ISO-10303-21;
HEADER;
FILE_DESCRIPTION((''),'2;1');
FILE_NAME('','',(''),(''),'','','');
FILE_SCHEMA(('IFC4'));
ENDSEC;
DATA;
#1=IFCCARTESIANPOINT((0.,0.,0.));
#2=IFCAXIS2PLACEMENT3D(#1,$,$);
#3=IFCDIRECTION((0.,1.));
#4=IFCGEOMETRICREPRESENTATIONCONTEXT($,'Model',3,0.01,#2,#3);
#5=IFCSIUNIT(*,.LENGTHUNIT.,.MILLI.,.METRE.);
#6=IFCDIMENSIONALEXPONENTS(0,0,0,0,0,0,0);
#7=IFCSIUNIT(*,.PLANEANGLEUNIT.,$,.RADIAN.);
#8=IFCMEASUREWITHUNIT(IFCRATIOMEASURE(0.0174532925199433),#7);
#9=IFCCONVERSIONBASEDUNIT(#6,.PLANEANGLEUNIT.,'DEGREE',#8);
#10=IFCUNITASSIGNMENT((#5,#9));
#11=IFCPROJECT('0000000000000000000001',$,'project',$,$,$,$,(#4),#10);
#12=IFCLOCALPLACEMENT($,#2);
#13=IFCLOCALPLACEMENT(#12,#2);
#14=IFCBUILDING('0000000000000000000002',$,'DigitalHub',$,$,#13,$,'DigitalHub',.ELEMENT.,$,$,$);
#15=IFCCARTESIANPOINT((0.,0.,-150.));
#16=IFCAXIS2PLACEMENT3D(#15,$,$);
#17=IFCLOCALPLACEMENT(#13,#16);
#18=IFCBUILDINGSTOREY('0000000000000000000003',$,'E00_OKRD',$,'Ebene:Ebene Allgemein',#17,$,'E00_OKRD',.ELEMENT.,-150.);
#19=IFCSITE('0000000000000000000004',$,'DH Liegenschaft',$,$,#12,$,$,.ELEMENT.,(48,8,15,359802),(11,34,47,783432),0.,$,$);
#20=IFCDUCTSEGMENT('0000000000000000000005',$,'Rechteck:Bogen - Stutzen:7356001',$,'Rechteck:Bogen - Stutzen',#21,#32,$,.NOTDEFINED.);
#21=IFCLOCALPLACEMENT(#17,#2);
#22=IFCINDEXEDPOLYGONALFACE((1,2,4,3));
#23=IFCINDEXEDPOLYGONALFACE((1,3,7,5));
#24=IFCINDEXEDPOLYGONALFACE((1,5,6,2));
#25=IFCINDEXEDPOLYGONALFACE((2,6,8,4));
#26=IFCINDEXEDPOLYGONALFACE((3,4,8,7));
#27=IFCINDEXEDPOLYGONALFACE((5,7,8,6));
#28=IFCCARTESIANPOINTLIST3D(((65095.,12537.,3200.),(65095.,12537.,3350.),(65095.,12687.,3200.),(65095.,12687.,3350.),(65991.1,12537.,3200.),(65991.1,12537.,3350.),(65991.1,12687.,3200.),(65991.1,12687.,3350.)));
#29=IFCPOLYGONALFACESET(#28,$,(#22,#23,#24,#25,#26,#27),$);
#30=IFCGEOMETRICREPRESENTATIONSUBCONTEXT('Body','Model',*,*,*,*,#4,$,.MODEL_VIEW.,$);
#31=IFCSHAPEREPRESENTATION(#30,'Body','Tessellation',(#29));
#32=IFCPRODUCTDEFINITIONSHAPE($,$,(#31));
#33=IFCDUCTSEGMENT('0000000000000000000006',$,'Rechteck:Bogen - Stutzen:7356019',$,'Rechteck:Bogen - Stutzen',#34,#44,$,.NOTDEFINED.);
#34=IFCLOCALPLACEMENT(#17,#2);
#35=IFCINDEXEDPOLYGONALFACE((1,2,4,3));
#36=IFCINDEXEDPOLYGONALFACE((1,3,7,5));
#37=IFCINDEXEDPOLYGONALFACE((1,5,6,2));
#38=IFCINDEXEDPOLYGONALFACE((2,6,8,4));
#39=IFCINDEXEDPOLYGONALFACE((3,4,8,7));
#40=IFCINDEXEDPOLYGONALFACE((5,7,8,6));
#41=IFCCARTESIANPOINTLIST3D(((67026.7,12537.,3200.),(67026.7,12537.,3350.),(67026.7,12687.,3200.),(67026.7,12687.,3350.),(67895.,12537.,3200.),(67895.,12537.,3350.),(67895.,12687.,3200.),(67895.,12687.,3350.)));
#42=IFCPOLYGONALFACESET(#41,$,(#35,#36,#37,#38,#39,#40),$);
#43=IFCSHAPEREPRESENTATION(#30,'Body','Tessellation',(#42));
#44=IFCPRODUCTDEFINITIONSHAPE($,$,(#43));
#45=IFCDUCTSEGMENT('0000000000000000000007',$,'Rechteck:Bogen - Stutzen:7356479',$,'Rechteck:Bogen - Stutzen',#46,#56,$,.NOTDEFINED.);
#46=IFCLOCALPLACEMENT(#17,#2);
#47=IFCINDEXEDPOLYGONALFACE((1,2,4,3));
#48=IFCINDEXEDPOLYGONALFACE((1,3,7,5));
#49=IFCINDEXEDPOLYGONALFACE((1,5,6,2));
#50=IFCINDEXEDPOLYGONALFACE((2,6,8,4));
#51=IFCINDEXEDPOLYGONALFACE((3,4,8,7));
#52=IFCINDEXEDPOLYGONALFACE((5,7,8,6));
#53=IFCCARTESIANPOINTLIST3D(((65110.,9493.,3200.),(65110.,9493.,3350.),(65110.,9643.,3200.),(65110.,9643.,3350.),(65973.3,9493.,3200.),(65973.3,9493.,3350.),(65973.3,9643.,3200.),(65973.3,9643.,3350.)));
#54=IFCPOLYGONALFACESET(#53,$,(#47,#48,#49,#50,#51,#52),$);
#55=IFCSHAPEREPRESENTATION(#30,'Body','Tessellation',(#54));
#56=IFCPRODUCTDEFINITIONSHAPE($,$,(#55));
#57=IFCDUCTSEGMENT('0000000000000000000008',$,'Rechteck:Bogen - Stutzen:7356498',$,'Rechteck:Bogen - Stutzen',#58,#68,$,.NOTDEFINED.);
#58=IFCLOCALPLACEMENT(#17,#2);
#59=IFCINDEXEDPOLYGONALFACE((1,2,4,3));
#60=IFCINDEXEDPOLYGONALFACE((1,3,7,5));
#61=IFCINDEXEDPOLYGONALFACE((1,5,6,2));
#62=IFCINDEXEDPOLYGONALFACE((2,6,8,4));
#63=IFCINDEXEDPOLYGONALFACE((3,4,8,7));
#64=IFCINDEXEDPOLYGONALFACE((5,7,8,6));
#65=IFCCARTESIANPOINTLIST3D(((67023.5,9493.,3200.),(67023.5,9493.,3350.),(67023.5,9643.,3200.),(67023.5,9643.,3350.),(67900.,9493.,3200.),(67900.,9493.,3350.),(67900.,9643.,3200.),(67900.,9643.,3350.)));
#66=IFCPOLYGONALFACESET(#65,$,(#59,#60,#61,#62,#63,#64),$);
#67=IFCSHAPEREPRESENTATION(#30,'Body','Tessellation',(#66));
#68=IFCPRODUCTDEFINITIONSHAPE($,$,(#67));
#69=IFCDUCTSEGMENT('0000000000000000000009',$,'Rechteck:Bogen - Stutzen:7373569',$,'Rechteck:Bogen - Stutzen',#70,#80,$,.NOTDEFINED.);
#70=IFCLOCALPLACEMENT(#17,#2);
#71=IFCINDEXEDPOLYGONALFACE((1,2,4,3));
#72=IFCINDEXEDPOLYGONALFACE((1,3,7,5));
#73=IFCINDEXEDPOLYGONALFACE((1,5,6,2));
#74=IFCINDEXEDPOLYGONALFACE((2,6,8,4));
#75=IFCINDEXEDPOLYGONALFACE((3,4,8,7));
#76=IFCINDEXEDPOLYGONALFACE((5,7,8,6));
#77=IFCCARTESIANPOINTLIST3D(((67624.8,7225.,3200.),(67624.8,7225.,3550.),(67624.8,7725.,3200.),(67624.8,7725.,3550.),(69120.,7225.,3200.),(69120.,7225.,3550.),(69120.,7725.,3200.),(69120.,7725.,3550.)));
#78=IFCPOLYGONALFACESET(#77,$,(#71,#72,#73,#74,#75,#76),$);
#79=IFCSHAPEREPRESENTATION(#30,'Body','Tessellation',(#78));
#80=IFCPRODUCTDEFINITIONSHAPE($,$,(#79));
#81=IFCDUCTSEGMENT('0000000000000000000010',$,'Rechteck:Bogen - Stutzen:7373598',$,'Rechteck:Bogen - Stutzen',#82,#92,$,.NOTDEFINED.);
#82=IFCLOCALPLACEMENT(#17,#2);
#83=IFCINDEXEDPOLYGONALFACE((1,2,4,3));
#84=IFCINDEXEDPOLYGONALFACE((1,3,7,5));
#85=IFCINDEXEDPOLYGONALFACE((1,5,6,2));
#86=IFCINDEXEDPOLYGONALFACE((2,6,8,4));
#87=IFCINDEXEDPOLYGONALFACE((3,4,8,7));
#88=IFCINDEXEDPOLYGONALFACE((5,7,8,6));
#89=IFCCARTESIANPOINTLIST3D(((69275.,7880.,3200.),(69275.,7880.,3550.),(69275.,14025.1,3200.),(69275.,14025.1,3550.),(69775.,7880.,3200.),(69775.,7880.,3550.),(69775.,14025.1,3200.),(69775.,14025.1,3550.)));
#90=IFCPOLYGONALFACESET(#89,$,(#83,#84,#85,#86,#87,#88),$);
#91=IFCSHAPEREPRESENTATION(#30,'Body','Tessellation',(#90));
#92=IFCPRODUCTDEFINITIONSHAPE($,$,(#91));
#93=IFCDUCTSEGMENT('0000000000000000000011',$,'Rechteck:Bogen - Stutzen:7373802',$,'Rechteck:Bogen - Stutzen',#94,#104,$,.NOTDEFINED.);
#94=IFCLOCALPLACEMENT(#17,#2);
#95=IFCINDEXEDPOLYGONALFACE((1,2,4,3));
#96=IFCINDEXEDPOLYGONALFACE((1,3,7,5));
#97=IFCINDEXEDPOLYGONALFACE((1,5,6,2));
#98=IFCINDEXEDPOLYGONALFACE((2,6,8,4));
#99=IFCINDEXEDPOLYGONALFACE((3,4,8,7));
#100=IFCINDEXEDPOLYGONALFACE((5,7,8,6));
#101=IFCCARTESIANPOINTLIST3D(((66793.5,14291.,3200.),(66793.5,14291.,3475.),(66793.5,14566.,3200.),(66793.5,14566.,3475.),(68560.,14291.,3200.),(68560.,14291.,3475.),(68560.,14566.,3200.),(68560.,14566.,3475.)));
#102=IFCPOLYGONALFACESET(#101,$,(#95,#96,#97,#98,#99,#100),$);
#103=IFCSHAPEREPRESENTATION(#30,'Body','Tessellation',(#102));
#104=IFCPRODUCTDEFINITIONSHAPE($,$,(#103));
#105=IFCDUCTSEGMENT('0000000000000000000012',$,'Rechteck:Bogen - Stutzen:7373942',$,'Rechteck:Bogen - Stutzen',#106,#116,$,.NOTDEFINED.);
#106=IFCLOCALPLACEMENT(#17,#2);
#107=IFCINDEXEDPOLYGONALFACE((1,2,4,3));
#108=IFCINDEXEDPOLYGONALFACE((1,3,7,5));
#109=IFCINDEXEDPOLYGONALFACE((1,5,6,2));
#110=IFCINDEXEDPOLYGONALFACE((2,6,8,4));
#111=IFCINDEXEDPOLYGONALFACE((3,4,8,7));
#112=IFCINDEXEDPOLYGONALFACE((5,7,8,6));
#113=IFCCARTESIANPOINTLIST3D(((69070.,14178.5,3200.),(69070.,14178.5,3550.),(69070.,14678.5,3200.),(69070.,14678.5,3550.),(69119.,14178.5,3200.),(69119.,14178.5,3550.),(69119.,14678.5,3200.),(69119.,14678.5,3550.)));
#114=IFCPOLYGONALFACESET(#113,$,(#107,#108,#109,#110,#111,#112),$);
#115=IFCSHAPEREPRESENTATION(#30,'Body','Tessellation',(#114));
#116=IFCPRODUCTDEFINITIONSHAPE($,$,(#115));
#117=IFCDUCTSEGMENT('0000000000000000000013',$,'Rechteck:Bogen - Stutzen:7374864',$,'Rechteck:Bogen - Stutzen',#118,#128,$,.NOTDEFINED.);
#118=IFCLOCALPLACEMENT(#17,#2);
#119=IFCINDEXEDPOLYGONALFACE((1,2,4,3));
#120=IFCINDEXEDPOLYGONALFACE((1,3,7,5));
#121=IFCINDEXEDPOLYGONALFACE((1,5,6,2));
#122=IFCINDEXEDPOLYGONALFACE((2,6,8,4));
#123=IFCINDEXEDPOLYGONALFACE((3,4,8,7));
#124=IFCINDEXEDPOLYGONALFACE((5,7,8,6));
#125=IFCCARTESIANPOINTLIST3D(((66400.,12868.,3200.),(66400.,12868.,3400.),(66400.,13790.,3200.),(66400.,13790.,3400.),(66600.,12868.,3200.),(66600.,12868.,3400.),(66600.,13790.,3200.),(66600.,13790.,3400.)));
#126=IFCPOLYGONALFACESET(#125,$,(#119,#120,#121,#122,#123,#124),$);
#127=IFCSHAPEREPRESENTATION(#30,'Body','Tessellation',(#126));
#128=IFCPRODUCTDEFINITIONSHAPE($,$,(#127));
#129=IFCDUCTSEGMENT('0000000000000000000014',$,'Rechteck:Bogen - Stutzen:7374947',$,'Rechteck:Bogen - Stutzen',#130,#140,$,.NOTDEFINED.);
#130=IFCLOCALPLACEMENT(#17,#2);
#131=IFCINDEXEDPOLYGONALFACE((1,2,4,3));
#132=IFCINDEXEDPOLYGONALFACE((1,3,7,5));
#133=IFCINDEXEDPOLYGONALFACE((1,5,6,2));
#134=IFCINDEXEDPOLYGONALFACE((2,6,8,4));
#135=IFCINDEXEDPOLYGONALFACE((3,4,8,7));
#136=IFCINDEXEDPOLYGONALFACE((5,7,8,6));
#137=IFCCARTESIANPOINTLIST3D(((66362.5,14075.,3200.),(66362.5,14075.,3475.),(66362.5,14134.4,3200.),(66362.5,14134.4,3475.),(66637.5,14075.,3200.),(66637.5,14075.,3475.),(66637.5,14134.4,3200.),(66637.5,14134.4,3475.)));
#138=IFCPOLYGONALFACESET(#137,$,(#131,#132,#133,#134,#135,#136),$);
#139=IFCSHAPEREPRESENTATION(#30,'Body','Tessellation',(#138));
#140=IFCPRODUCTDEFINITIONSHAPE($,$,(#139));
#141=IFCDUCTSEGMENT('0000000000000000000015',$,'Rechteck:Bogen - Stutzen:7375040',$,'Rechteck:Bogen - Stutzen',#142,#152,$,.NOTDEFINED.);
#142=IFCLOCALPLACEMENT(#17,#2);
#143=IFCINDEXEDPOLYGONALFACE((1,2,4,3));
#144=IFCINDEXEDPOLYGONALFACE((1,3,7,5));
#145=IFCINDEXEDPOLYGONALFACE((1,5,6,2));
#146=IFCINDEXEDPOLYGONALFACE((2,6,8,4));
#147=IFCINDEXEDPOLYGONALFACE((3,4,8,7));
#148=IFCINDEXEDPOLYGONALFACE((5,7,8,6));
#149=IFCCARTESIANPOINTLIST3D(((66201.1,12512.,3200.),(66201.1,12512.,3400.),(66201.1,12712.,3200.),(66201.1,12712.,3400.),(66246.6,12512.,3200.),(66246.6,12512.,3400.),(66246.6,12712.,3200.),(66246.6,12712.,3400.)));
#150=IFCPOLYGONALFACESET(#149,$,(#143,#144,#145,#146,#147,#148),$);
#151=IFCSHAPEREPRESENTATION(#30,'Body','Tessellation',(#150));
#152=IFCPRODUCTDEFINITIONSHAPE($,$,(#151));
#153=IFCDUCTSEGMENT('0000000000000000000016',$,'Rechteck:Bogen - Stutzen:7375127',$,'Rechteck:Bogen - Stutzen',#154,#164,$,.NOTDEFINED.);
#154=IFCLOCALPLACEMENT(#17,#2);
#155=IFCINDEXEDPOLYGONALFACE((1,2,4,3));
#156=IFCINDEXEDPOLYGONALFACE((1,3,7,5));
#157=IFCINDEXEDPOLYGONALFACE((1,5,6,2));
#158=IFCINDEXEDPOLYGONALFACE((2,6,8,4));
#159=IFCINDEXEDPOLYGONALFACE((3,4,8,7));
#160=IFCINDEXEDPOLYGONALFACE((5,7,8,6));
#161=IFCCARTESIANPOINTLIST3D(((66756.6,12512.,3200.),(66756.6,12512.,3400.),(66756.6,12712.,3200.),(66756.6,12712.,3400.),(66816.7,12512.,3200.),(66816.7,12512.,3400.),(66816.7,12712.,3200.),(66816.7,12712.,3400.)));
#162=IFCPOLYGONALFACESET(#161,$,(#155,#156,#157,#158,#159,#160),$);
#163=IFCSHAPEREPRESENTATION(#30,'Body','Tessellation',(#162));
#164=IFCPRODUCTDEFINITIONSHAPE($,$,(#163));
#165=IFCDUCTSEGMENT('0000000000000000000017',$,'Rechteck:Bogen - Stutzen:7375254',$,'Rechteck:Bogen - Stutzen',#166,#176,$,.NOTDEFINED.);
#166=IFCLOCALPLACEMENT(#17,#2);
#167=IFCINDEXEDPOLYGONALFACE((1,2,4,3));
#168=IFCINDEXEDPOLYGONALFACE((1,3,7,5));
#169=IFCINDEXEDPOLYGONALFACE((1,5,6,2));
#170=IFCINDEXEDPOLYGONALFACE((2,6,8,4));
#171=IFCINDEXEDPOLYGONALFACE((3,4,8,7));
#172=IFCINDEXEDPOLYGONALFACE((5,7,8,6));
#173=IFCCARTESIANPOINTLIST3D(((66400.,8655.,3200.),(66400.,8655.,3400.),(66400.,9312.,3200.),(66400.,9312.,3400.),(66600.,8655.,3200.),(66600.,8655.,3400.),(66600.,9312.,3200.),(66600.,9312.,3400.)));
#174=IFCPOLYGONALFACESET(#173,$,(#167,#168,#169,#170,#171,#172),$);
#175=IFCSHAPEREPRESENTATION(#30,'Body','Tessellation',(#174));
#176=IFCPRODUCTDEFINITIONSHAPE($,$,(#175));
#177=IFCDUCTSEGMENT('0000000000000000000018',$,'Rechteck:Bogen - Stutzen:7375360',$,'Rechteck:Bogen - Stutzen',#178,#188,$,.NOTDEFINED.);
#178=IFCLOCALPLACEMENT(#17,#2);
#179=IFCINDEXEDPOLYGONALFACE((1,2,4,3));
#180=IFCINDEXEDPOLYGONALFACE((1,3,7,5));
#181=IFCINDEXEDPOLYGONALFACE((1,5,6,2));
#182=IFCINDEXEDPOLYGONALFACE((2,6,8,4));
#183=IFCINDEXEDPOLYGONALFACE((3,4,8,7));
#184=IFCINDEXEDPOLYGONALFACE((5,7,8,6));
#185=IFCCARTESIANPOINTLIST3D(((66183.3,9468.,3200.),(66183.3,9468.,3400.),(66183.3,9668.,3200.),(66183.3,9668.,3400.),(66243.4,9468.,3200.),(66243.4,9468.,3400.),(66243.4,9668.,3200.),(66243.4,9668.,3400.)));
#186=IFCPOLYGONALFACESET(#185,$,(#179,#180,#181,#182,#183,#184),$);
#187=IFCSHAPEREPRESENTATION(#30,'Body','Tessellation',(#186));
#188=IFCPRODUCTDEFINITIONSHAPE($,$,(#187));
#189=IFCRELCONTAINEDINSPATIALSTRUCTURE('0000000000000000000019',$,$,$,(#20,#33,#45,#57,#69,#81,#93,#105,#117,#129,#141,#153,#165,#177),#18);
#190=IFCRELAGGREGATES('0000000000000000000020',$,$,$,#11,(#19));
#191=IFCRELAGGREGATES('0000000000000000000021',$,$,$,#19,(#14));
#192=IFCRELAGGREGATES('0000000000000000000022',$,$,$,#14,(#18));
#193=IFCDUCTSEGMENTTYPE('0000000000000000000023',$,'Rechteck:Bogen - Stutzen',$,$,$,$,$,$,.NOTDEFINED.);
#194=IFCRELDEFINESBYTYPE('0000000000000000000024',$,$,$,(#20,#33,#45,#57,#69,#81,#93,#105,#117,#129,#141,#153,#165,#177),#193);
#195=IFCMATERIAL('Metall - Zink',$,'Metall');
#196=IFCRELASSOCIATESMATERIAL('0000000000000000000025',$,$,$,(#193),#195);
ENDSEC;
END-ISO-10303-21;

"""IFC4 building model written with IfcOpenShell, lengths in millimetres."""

from ifc_helpers import new_model, entity, si_unit, converted_unit, direction, frame, origin, place, context, subcontext, project, spatial, indexed_curve, outline, extrude, material, type_object, element, save


model = new_model("IFC4")

# Units and contexts
model_context = context("Model", 3, precision=0.01, world=origin(), true_north=direction((0.0, 1.0)))
body_context = subcontext(model_context, "Body", "Model", "MODEL_VIEW")
ifc_project = project(units=[si_unit("LENGTHUNIT", "METRE", prefix="MILLI"), converted_unit("PLANEANGLEUNIT", "DEGREE", entity("IfcRatioMeasure", 0.0174532925199433), si_unit("PLANEANGLEUNIT", "RADIAN"), dimensions=[0, 0, 0, 0, 0, 0, 0])], contexts=[model_context])

# Site, building, storey
site_placement = place(None, origin())
site = spatial("IfcSite", under=ifc_project, at=site_placement, Name="DH Liegenschaft", CompositionType="ELEMENT", RefLatitude=(48, 8, 15, 359802), RefLongitude=(11, 34, 47, 783432), RefElevation=0.0)
building_placement = place(site_placement, origin())
building = spatial("IfcBuilding", under=site, at=building_placement, Name="DigitalHub", LongName="DigitalHub", CompositionType="ELEMENT")
storey_placement = place(building_placement, frame((0.0, 0.0, -150.0)))
storey = spatial("IfcBuildingStorey", under=building, at=storey_placement, Name="E00_OKRD", ObjectType="Ebene:Ebene Allgemein", LongName="E00_OKRD", CompositionType="ELEMENT", Elevation=-150.0)

# Duct segments
ifc_material_1 = material(Name="Metall - Zink", Category="Metall")
duct_segment_type_1 = type_object("IfcDuctSegmentType", Name="Rechteck:Bogen - Stutzen", PredefinedType="NOTDEFINED", material=ifc_material_1)
duct_segment_1_placement = place(storey_placement, frame((65095.0, 12537.0, 3200.0)))
element("IfcDuctSegment", 1, at=duct_segment_1_placement, inside=storey, type_object=duct_segment_type_1, Name="Rechteck:Bogen - Stutzen:7356001", ObjectType="Rechteck:Bogen - Stutzen", PredefinedType="NOTDEFINED", context=body_context, shape_type="SweptSolid", body=[
    extrude(outline(indexed_curve([(-448.1, -75.0), (448.1, -75.0), (448.1, 75.0), (-448.1, 75.0), (-448.1, -75.0)], self_intersect=False)), frame((448.1, 75.0, 0.0)), (0.0, 0.0, 1.0), 150.0),
])
duct_segment_2_placement = place(storey_placement, frame((67026.7, 12537.0, 3200.0)))
element("IfcDuctSegment", 2, at=duct_segment_2_placement, inside=storey, type_object=duct_segment_type_1, Name="Rechteck:Bogen - Stutzen:7356019", ObjectType="Rechteck:Bogen - Stutzen", PredefinedType="NOTDEFINED", context=body_context, shape_type="SweptSolid", body=[
    extrude(outline(indexed_curve([(-434.2, -75.0), (434.2, -75.0), (434.2, 75.0), (-434.2, 75.0), (-434.2, -75.0)], self_intersect=False)), frame((434.2, 75.0, 0.0), z_axis=(0.0, 0.0, 1.0), x_axis=(-1.0, 0.0, 0.0)), (0.0, 0.0, 1.0), 150.0),
])
duct_segment_3_placement = place(storey_placement, frame((65110.0, 9493.0, 3200.0)))
element("IfcDuctSegment", 3, at=duct_segment_3_placement, inside=storey, type_object=duct_segment_type_1, Name="Rechteck:Bogen - Stutzen:7356479", ObjectType="Rechteck:Bogen - Stutzen", PredefinedType="NOTDEFINED", context=body_context, shape_type="SweptSolid", body=[
    extrude(outline(indexed_curve([(-431.7, -75.0), (431.7, -75.0), (431.7, 75.0), (-431.7, 75.0), (-431.7, -75.0)], self_intersect=False)), frame((431.7, 75.0, 0.0)), (0.0, 0.0, 1.0), 150.0),
])
duct_segment_4_placement = place(storey_placement, frame((67023.5, 9493.0, 3200.0)))
element("IfcDuctSegment", 4, at=duct_segment_4_placement, inside=storey, type_object=duct_segment_type_1, Name="Rechteck:Bogen - Stutzen:7356498", ObjectType="Rechteck:Bogen - Stutzen", PredefinedType="NOTDEFINED", context=body_context, shape_type="SweptSolid", body=[
    extrude(outline(indexed_curve([(-438.3, -75.0), (438.3, -75.0), (438.3, 75.0), (-438.3, 75.0), (-438.3, -75.0)], self_intersect=False)), frame((438.3, 75.0, 0.0), z_axis=(0.0, 0.0, 1.0), x_axis=(-1.0, 0.0, 0.0)), (0.0, 0.0, 1.0), 150.0),
])
duct_segment_5_placement = place(storey_placement, frame((67624.8, 7225.0, 3200.0)))
element("IfcDuctSegment", 5, at=duct_segment_5_placement, inside=storey, type_object=duct_segment_type_1, Name="Rechteck:Bogen - Stutzen:7373569", ObjectType="Rechteck:Bogen - Stutzen", PredefinedType="NOTDEFINED", context=body_context, shape_type="SweptSolid", body=[
    extrude(outline(indexed_curve([(-747.6, -250.0), (747.6, -250.0), (747.6, 250.0), (-747.6, 250.0), (-747.6, -250.0)], self_intersect=False)), frame((747.6, 250.0, 0.0), z_axis=(0.0, 0.0, 1.0), x_axis=(-1.0, 0.0, 0.0)), (0.0, 0.0, 1.0), 350.0),
])
duct_segment_6_placement = place(storey_placement, frame((69275.0, 7880.0, 3200.0)))
element("IfcDuctSegment", 6, at=duct_segment_6_placement, inside=storey, type_object=duct_segment_type_1, Name="Rechteck:Bogen - Stutzen:7373598", ObjectType="Rechteck:Bogen - Stutzen", PredefinedType="NOTDEFINED", context=body_context, shape_type="SweptSolid", body=[
    extrude(outline(indexed_curve([(-3072.6, -250.0), (3072.6, -250.0), (3072.6, 250.0), (-3072.6, 250.0), (-3072.6, -250.0)], self_intersect=False)), frame((250.0, 3072.6, 0.0), z_axis=(0.0, 0.0, 1.0), x_axis=(0.0, 1.0, 0.0)), (0.0, 0.0, 1.0), 350.0),
])
duct_segment_7_placement = place(storey_placement, frame((66793.5, 14291.0, 3200.0)))
element("IfcDuctSegment", 7, at=duct_segment_7_placement, inside=storey, type_object=duct_segment_type_1, Name="Rechteck:Bogen - Stutzen:7373802", ObjectType="Rechteck:Bogen - Stutzen", PredefinedType="NOTDEFINED", context=body_context, shape_type="SweptSolid", body=[
    extrude(outline(indexed_curve([(-883.3, -137.5), (883.2, -137.5), (883.2, 137.5), (-883.3, 137.5), (-883.3, -137.5)], self_intersect=False)), frame((883.2, 137.5, 0.0)), (0.0, 0.0, 1.0), 275.0),
])
duct_segment_8_placement = place(storey_placement, frame((69070.0, 14178.5, 3200.0)))
element("IfcDuctSegment", 8, at=duct_segment_8_placement, inside=storey, type_object=duct_segment_type_1, Name="Rechteck:Bogen - Stutzen:7373942", ObjectType="Rechteck:Bogen - Stutzen", PredefinedType="NOTDEFINED", context=body_context, shape_type="SweptSolid", body=[
    extrude(outline(indexed_curve([(-24.5, -250.0), (24.5, -250.0), (24.5, 250.0), (-24.5, 250.0), (-24.5, -250.0)], self_intersect=False)), frame((24.5, 250.0, 0.0)), (0.0, 0.0, 1.0), 350.0),
])
duct_segment_9_placement = place(storey_placement, frame((66400.0, 12868.0, 3200.0)))
element("IfcDuctSegment", 9, at=duct_segment_9_placement, inside=storey, type_object=duct_segment_type_1, Name="Rechteck:Bogen - Stutzen:7374864", ObjectType="Rechteck:Bogen - Stutzen", PredefinedType="NOTDEFINED", context=body_context, shape_type="SweptSolid", body=[
    extrude(outline(indexed_curve([(-461.0, -100.0), (461.0, -100.0), (461.0, 100.0), (-461.0, 100.0), (-461.0, -100.0)], self_intersect=False)), frame((100.0, 461.0, 0.0), z_axis=(0.0, 0.0, 1.0), x_axis=(0.0, 1.0, 0.0)), (0.0, 0.0, 1.0), 200.0),
])
duct_segment_10_placement = place(storey_placement, frame((66362.5, 14075.0, 3200.0)))
element("IfcDuctSegment", 10, at=duct_segment_10_placement, inside=storey, type_object=duct_segment_type_1, Name="Rechteck:Bogen - Stutzen:7374947", ObjectType="Rechteck:Bogen - Stutzen", PredefinedType="NOTDEFINED", context=body_context, shape_type="SweptSolid", body=[
    extrude(outline(indexed_curve([(-29.7, -137.5), (29.7, -137.5), (29.7, 137.5), (-29.7, 137.5), (-29.7, -137.5)], self_intersect=False)), frame((137.5, 29.7, 0.0), z_axis=(0.0, 0.0, 1.0), x_axis=(0.0, -1.0, 0.0)), (0.0, 0.0, 1.0), 275.0),
])
duct_segment_11_placement = place(storey_placement, frame((66201.1, 12512.0, 3200.0)))
element("IfcDuctSegment", 11, at=duct_segment_11_placement, inside=storey, type_object=duct_segment_type_1, Name="Rechteck:Bogen - Stutzen:7375040", ObjectType="Rechteck:Bogen - Stutzen", PredefinedType="NOTDEFINED", context=body_context, shape_type="SweptSolid", body=[
    extrude(outline(indexed_curve([(-22.7, -100.0), (22.7, -100.0), (22.7, 100.0), (-22.7, 100.0), (-22.7, -100.0)], self_intersect=False)), frame((22.7, 100.0, 0.0), z_axis=(0.0, 0.0, 1.0), x_axis=(-1.0, 0.0, 0.0)), (0.0, 0.0, 1.0), 200.0),
])
duct_segment_12_placement = place(storey_placement, frame((66756.6, 12512.0, 3200.0)))
element("IfcDuctSegment", 12, at=duct_segment_12_placement, inside=storey, type_object=duct_segment_type_1, Name="Rechteck:Bogen - Stutzen:7375127", ObjectType="Rechteck:Bogen - Stutzen", PredefinedType="NOTDEFINED", context=body_context, shape_type="SweptSolid", body=[
    extrude(outline(indexed_curve([(-30.0, -100.0), (30.0, -100.0), (30.0, 100.0), (-30.0, 100.0), (-30.0, -100.0)], self_intersect=False)), frame((30.0, 100.0, 0.0)), (0.0, 0.0, 1.0), 200.0),
])
duct_segment_13_placement = place(storey_placement, frame((66400.0, 8655.0, 3200.0)))
element("IfcDuctSegment", 13, at=duct_segment_13_placement, inside=storey, type_object=duct_segment_type_1, Name="Rechteck:Bogen - Stutzen:7375254", ObjectType="Rechteck:Bogen - Stutzen", PredefinedType="NOTDEFINED", context=body_context, shape_type="SweptSolid", body=[
    extrude(outline(indexed_curve([(-328.5, -100.0), (328.5, -100.0), (328.5, 100.0), (-328.5, 100.0), (-328.5, -100.0)], self_intersect=False)), frame((100.0, 328.5, 0.0), z_axis=(0.0, 0.0, 1.0), x_axis=(0.0, -1.0, 0.0)), (0.0, 0.0, 1.0), 200.0),
])
duct_segment_14_placement = place(storey_placement, frame((66183.3, 9468.0, 3200.0)))
element("IfcDuctSegment", 14, at=duct_segment_14_placement, inside=storey, type_object=duct_segment_type_1, Name="Rechteck:Bogen - Stutzen:7375360", ObjectType="Rechteck:Bogen - Stutzen", PredefinedType="NOTDEFINED", context=body_context, shape_type="SweptSolid", body=[
    extrude(outline(indexed_curve([(-30.0, -100.0), (30.0, -100.0), (30.0, 100.0), (-30.0, 100.0), (-30.0, -100.0)], self_intersect=False)), frame((30.0, 100.0, 0.0), z_axis=(0.0, 0.0, 1.0), x_axis=(-1.0, 0.0, 0.0)), (0.0, 0.0, 1.0), 200.0),
])

save(model, "model.ifc")
